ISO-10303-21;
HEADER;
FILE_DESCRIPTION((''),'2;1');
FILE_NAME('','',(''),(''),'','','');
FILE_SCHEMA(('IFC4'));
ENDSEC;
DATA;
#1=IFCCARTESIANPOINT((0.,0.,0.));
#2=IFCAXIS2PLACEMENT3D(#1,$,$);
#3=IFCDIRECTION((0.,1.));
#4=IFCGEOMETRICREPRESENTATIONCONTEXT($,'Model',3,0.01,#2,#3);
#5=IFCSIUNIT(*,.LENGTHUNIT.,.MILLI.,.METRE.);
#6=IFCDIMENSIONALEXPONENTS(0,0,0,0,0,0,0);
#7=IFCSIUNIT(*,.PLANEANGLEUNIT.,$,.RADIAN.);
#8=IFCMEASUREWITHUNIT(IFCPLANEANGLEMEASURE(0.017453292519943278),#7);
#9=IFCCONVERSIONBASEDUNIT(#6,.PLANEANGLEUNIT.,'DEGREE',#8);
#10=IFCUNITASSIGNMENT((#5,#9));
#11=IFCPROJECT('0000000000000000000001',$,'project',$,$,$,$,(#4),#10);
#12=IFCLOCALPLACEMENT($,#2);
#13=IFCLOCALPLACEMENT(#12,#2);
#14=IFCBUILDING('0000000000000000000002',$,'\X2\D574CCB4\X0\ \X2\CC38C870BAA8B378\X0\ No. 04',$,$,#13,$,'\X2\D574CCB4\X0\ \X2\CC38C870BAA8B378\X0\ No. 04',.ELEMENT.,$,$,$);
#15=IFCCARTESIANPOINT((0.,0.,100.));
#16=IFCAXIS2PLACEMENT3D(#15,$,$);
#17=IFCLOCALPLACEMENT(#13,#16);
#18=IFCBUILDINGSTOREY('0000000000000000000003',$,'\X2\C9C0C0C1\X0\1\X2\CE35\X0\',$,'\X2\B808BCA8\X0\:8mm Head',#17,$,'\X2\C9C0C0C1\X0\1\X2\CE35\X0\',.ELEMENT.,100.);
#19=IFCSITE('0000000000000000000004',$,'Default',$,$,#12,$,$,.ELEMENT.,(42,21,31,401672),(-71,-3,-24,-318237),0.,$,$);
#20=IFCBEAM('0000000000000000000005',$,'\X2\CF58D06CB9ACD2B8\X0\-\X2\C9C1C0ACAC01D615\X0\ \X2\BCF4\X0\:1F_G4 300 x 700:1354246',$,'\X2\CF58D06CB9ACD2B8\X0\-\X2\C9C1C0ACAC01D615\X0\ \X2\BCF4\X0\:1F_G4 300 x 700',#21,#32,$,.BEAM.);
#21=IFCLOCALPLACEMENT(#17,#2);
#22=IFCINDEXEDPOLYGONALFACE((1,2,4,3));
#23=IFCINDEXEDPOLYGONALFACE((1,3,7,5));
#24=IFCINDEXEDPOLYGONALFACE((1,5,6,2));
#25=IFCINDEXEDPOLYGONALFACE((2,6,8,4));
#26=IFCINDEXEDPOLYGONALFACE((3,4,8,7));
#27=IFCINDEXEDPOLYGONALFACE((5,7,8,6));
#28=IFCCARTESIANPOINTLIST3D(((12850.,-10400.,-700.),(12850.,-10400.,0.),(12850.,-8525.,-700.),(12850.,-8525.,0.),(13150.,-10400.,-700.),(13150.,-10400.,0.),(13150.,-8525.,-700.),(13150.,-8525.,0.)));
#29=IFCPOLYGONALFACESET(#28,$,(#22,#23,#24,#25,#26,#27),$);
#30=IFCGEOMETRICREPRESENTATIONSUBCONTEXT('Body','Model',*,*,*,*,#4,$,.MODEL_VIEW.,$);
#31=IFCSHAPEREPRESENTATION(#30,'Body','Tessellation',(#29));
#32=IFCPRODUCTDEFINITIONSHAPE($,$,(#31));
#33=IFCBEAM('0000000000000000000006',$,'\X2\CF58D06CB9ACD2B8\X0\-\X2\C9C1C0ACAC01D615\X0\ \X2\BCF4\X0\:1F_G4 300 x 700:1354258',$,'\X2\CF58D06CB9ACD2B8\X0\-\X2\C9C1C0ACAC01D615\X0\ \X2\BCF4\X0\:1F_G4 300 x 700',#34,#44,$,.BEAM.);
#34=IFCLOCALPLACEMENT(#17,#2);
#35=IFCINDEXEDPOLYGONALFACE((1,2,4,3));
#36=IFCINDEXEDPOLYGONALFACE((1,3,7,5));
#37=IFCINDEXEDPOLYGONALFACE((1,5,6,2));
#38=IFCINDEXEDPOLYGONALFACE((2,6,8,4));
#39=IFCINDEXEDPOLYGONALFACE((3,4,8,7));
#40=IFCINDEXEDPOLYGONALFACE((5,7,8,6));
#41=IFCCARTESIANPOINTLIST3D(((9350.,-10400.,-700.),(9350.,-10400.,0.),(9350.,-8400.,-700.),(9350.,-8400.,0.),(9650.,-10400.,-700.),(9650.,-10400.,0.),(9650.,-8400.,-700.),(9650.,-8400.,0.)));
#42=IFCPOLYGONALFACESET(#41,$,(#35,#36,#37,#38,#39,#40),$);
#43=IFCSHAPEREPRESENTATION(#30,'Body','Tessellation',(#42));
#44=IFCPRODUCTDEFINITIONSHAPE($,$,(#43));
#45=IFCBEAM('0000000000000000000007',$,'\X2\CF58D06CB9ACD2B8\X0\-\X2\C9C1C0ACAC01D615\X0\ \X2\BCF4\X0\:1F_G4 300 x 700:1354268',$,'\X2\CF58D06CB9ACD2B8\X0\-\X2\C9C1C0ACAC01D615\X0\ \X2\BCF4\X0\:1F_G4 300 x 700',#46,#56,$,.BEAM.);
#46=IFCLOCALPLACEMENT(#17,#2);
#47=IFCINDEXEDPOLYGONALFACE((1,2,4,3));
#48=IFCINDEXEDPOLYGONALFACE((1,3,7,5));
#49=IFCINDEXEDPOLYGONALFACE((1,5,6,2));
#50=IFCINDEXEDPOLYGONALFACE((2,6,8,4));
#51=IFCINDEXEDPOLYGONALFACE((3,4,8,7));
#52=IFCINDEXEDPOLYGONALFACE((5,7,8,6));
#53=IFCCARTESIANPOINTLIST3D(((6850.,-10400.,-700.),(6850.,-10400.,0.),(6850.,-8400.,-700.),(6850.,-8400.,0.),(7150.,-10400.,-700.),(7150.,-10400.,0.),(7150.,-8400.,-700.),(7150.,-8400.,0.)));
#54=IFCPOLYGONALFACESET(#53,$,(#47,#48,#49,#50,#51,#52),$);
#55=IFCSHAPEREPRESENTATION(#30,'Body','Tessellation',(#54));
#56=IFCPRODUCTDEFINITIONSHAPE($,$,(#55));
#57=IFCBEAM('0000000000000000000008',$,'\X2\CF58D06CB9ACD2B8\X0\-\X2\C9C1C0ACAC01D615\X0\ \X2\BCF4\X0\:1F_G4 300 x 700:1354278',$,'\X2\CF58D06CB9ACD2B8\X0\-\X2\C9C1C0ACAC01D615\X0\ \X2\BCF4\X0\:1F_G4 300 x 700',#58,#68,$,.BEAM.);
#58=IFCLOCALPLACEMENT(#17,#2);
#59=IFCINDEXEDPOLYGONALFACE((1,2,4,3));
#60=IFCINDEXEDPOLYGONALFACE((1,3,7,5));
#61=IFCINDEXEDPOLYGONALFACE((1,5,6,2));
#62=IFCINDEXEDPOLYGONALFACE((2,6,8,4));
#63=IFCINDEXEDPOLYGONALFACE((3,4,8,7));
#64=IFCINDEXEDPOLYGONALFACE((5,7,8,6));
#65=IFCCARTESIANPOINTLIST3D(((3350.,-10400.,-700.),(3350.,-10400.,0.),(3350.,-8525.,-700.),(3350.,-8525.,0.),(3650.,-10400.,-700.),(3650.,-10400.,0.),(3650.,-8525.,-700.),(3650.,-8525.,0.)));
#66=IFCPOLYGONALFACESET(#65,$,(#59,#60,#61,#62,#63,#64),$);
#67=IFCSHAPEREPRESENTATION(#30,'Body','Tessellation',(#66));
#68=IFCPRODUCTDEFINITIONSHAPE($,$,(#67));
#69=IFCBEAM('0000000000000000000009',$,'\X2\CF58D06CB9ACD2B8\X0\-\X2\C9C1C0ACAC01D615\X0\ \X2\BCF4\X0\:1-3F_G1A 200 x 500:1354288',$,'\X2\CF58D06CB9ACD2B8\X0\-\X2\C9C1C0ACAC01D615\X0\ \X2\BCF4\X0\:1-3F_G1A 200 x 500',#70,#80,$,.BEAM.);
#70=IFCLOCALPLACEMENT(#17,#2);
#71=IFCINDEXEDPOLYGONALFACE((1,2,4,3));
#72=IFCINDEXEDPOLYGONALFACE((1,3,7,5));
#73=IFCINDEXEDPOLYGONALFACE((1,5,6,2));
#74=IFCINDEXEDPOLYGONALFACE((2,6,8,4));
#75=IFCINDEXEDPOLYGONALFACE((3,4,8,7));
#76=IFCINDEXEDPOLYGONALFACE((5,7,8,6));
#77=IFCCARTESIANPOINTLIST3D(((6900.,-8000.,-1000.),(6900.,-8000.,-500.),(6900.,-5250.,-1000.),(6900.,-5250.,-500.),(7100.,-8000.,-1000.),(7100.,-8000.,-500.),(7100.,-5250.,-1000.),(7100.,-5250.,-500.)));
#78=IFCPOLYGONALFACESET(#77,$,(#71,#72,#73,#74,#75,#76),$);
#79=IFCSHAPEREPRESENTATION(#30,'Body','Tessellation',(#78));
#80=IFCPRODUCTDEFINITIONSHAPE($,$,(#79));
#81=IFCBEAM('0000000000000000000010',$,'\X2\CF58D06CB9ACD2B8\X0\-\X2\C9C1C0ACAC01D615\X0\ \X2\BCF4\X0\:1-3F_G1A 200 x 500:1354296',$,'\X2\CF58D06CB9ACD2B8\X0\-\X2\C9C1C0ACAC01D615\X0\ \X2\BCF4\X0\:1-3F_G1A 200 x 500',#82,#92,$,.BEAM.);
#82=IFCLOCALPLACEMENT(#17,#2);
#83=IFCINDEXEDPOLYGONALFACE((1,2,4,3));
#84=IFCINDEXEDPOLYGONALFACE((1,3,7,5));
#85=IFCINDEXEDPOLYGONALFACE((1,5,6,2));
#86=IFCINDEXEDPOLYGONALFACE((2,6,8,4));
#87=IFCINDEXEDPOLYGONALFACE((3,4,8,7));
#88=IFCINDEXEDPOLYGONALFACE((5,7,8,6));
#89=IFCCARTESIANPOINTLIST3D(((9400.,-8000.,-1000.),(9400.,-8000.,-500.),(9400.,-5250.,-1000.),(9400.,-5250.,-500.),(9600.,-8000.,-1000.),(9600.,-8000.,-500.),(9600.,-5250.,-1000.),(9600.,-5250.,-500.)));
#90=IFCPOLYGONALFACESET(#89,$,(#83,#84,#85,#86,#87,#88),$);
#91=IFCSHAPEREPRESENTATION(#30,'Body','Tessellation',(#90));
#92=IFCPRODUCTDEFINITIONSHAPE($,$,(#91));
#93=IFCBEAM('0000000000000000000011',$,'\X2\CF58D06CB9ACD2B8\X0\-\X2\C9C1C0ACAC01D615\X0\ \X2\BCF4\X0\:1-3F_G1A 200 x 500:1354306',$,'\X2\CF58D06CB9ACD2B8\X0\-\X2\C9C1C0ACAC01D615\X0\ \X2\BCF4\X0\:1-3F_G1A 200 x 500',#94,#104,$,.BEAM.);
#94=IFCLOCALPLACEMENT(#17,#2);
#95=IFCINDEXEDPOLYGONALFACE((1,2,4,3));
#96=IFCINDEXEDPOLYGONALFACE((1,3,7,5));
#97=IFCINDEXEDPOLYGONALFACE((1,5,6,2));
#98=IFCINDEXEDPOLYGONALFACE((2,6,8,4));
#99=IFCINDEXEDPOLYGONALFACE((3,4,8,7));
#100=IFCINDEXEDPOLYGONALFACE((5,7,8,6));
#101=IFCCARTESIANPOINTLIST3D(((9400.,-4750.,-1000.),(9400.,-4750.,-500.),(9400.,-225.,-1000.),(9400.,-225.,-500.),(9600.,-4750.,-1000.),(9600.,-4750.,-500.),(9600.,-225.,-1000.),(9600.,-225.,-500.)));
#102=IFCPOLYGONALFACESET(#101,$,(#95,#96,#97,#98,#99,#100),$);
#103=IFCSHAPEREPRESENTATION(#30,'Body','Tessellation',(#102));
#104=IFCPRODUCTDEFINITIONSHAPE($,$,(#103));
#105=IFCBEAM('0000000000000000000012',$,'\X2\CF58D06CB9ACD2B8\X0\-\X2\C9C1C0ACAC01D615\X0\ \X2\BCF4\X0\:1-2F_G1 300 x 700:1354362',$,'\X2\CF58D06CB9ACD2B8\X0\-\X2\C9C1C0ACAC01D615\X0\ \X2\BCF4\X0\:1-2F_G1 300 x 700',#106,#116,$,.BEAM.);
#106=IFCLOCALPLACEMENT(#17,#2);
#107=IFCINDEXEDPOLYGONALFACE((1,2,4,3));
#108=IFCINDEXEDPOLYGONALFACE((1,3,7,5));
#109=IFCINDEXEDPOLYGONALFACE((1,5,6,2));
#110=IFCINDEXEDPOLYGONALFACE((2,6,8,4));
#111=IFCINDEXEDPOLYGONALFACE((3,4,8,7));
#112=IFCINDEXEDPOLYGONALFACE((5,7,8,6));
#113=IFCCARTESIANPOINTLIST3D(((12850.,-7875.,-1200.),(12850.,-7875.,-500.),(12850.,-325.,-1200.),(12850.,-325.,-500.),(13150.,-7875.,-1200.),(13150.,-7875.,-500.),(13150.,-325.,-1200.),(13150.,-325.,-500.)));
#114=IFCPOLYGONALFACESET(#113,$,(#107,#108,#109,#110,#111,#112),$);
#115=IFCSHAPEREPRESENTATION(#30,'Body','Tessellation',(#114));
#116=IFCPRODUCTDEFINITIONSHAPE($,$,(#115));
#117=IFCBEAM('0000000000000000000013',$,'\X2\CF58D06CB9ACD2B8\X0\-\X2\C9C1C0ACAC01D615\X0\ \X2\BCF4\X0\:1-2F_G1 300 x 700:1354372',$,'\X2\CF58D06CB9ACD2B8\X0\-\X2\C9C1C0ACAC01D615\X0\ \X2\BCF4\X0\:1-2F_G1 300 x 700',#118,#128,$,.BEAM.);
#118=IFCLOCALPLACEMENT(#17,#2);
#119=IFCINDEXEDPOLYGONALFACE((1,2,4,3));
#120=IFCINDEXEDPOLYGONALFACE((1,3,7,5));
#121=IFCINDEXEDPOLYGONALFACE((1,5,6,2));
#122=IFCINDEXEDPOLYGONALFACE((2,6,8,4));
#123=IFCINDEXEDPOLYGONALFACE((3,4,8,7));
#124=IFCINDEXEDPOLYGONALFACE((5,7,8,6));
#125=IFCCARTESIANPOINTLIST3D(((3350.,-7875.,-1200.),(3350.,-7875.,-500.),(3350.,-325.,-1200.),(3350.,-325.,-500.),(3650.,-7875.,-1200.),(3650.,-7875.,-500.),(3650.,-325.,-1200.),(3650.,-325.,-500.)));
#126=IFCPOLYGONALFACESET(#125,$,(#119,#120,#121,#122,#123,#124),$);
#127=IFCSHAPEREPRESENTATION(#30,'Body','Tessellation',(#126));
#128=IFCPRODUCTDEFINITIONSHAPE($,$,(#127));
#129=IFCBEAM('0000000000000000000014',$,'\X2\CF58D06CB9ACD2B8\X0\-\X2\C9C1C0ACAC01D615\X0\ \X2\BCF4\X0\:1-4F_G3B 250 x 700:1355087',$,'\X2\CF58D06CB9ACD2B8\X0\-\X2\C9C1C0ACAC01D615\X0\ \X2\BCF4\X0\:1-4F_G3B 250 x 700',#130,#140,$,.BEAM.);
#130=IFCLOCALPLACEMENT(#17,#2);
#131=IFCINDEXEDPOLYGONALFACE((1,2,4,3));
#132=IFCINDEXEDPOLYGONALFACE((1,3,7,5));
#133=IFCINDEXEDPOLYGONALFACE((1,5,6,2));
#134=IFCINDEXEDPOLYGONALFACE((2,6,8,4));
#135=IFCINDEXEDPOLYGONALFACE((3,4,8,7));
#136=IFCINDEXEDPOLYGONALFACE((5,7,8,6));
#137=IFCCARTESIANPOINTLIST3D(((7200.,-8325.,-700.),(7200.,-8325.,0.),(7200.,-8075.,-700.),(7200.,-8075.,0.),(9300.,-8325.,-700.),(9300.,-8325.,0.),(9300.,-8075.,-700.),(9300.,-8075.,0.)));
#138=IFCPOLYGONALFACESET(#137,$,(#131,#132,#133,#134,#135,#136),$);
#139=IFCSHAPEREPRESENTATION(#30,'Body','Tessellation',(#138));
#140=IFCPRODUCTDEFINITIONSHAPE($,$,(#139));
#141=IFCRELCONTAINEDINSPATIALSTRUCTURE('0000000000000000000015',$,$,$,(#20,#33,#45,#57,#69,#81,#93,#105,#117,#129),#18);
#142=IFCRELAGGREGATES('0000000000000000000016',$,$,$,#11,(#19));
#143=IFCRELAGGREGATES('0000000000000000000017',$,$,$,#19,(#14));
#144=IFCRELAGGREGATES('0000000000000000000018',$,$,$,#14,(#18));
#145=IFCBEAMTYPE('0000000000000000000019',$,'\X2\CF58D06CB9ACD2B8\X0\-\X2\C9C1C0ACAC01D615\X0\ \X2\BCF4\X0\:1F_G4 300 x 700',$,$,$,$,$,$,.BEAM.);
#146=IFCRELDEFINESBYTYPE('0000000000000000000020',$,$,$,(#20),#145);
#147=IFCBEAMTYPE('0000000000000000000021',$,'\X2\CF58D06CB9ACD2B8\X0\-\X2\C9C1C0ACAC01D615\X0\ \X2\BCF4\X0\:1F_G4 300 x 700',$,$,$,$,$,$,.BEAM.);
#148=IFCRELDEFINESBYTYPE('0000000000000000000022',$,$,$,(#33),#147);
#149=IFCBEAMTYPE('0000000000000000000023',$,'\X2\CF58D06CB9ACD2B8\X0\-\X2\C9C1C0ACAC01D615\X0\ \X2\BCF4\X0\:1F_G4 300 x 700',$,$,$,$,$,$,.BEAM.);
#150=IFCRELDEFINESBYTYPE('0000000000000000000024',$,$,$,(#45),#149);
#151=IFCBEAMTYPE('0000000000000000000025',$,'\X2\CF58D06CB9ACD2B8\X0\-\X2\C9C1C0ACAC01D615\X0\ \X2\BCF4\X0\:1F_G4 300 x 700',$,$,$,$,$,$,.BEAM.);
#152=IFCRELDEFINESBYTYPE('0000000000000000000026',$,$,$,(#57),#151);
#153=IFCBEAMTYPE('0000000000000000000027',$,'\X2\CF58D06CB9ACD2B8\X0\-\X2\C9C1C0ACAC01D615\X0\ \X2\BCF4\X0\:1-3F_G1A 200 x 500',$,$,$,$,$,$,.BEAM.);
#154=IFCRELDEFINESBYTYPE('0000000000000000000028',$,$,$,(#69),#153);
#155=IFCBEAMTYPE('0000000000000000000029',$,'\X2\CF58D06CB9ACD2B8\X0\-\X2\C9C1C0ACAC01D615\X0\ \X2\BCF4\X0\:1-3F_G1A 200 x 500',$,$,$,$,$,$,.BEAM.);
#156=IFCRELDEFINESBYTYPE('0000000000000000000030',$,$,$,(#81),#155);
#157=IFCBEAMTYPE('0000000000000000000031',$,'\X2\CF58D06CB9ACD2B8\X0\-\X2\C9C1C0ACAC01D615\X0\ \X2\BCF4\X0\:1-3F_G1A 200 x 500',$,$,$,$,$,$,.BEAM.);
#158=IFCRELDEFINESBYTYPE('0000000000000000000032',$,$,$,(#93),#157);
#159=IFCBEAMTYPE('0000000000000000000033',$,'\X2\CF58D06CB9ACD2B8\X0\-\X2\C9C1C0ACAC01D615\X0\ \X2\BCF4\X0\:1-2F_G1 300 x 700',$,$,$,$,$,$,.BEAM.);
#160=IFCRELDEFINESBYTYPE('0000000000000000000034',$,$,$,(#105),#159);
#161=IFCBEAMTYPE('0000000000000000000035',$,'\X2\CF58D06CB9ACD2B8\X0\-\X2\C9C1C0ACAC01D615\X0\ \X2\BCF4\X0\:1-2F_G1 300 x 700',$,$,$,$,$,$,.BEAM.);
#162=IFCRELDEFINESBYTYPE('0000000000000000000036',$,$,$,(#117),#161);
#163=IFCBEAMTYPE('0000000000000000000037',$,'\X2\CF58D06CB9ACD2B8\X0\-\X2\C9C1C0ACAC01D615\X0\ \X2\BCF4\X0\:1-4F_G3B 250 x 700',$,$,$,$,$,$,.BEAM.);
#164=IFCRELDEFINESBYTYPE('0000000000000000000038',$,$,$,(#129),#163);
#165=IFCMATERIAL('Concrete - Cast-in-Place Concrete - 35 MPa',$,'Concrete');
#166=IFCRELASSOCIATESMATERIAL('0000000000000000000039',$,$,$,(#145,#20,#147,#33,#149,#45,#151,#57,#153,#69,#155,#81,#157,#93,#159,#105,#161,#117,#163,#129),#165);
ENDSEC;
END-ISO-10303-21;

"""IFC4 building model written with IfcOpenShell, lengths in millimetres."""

from ifc_helpers import new_model, entity, si_unit, converted_unit, direction, frame, origin, place, context, subcontext, project, spatial, indexed_curve, outline, extrude, source, transform, mapped, material, type_object, type_shapes, element, save


model = new_model("IFC4")

# Units and contexts
model_context = context("Model", 3, precision=0.01, world=origin(), true_north=direction((0.0, 1.0)))
body_context = subcontext(model_context, "Body", "Model", "MODEL_VIEW")
ifc_project = project(units=[si_unit("LENGTHUNIT", "METRE", prefix="MILLI"), converted_unit("PLANEANGLEUNIT", "DEGREE", entity("IfcPlaneAngleMeasure", 0.017453292519943278), si_unit("PLANEANGLEUNIT", "RADIAN"), dimensions=[0, 0, 0, 0, 0, 0, 0])], contexts=[model_context])

# Site, building, storey
site_placement = place(None, origin())
site = spatial("IfcSite", under=ifc_project, at=site_placement, Name="Default", CompositionType="ELEMENT", RefLatitude=(42, 21, 31, 401672), RefLongitude=(-71, -3, -24, -318237), RefElevation=0.0)
building_placement = place(site_placement, origin())
building = spatial("IfcBuilding", under=site, at=building_placement, Name="해체 참조모델 No. 04", LongName="해체 참조모델 No. 04", CompositionType="ELEMENT")
storey_placement = place(building_placement, frame((0.0, 0.0, 100.0)))
storey = spatial("IfcBuildingStorey", under=building, at=storey_placement, Name="지상1층", ObjectType="레벨:8mm Head", LongName="지상1층", CompositionType="ELEMENT", Elevation=100.0)

# Beams
ifc_material = material(Name="Concrete - Cast-in-Place Concrete - 35 MPa", Category="Concrete")
beam_type_1 = type_object("IfcBeamType", Name="콘크리트-직사각형 보:1F_G4 300 x 700", PredefinedType="BEAM", material=ifc_material)
shared_shape_1 = source(origin(), body_context, "Body", "SweptSolid", [
    extrude(outline(indexed_curve([(-150.0, -350.0), (150.0, -350.0), (150.0, 350.0), (-150.0, 350.0), (-150.0, -350.0)], self_intersect=False)), frame((13000.0, -8525.0, -250.0), z_axis=(0.0, -1.0, 0.0), x_axis=(-1.0, 0.0, 0.0)), (0.0, 0.0, 1.0), 1875.0),
])
type_shapes(beam_type_1, [shared_shape_1])
beam_1_placement = place(storey_placement, frame((0.0, 0.0, -100.0)))
element("IfcBeam", 1, at=beam_1_placement, inside=storey, type_object=beam_type_1, material=ifc_material, Name="콘크리트-직사각형 보:1F_G4 300 x 700:1354246", ObjectType="콘크리트-직사각형 보:1F_G4 300 x 700", PredefinedType="BEAM", context=body_context, shape_type="MappedRepresentation", body=[
    mapped(shared_shape_1, transform((0.0, 0.0, 0.0), scale=1.0)),
])
beam_type_2 = type_object("IfcBeamType", Name="콘크리트-직사각형 보:1F_G4 300 x 700", PredefinedType="BEAM", material=ifc_material)
shared_shape_2 = source(origin(), body_context, "Body", "SweptSolid", [
    extrude(outline(indexed_curve([(-150.0, -350.0), (150.0, -350.0), (150.0, 350.0), (-150.0, 350.0), (-150.0, -350.0)], self_intersect=False)), frame((9500.0, -8400.0, -250.0), z_axis=(0.0, -1.0, 0.0), x_axis=(-1.0, 0.0, 0.0)), (0.0, 0.0, 1.0), 2000.0),
])
type_shapes(beam_type_2, [shared_shape_2])
beam_2_placement = place(storey_placement, frame((0.0, 0.0, -100.0)))
element("IfcBeam", 2, at=beam_2_placement, inside=storey, type_object=beam_type_2, material=ifc_material, Name="콘크리트-직사각형 보:1F_G4 300 x 700:1354258", ObjectType="콘크리트-직사각형 보:1F_G4 300 x 700", PredefinedType="BEAM", context=body_context, shape_type="MappedRepresentation", body=[
    mapped(shared_shape_2, transform((0.0, 0.0, 0.0), scale=1.0)),
])
beam_type_3 = type_object("IfcBeamType", Name="콘크리트-직사각형 보:1F_G4 300 x 700", PredefinedType="BEAM", material=ifc_material)
shared_shape_3 = source(origin(), body_context, "Body", "SweptSolid", [
    extrude(outline(indexed_curve([(-150.0, -350.0), (150.0, -350.0), (150.0, 350.0), (-150.0, 350.0), (-150.0, -350.0)], self_intersect=False)), frame((7000.0, -8400.0, -250.0), z_axis=(0.0, -1.0, 0.0), x_axis=(-1.0, 0.0, 0.0)), (0.0, 0.0, 1.0), 2000.0),
])
type_shapes(beam_type_3, [shared_shape_3])
beam_3_placement = place(storey_placement, frame((0.0, 0.0, -100.0)))
element("IfcBeam", 3, at=beam_3_placement, inside=storey, type_object=beam_type_3, material=ifc_material, Name="콘크리트-직사각형 보:1F_G4 300 x 700:1354268", ObjectType="콘크리트-직사각형 보:1F_G4 300 x 700", PredefinedType="BEAM", context=body_context, shape_type="MappedRepresentation", body=[
    mapped(shared_shape_3, transform((0.0, 0.0, 0.0), scale=1.0)),
])
beam_type_4 = type_object("IfcBeamType", Name="콘크리트-직사각형 보:1F_G4 300 x 700", PredefinedType="BEAM", material=ifc_material)
shared_shape_4 = source(origin(), body_context, "Body", "SweptSolid", [
    extrude(outline(indexed_curve([(-150.0, -350.0), (150.0, -350.0), (150.0, 350.0), (-150.0, 350.0), (-150.0, -350.0)], self_intersect=False)), frame((3500.0, -8525.0, -250.0), z_axis=(0.0, -1.0, 0.0), x_axis=(-1.0, 0.0, 0.0)), (0.0, 0.0, 1.0), 1875.0),
])
type_shapes(beam_type_4, [shared_shape_4])
beam_4_placement = place(storey_placement, frame((0.0, 0.0, -100.0)))
element("IfcBeam", 4, at=beam_4_placement, inside=storey, type_object=beam_type_4, material=ifc_material, Name="콘크리트-직사각형 보:1F_G4 300 x 700:1354278", ObjectType="콘크리트-직사각형 보:1F_G4 300 x 700", PredefinedType="BEAM", context=body_context, shape_type="MappedRepresentation", body=[
    mapped(shared_shape_4, transform((0.0, 0.0, 0.0), scale=1.0)),
])
beam_type_5 = type_object("IfcBeamType", Name="콘크리트-직사각형 보:1-3F_G1A 200 x 500", PredefinedType="BEAM", material=ifc_material)
shared_shape_5 = source(origin(), body_context, "Body", "SweptSolid", [
    extrude(outline(indexed_curve([(-100.0, -250.0), (100.0, -250.0), (100.0, 250.0), (-100.0, 250.0), (-100.0, -250.0)], self_intersect=False)), frame((7000.0, -5250.0, -650.0), z_axis=(0.0, -1.0, 0.0), x_axis=(-1.0, 0.0, 0.0)), (0.0, 0.0, 1.0), 2750.0),
])
type_shapes(beam_type_5, [shared_shape_5])
beam_5_placement = place(storey_placement, frame((0.0, 0.0, -100.0)))
element("IfcBeam", 5, at=beam_5_placement, inside=storey, type_object=beam_type_5, material=ifc_material, Name="콘크리트-직사각형 보:1-3F_G1A 200 x 500:1354288", ObjectType="콘크리트-직사각형 보:1-3F_G1A 200 x 500", PredefinedType="BEAM", context=body_context, shape_type="MappedRepresentation", body=[
    mapped(shared_shape_5, transform((0.0, 0.0, 0.0), scale=1.0)),
])
beam_type_6 = type_object("IfcBeamType", Name="콘크리트-직사각형 보:1-3F_G1A 200 x 500", PredefinedType="BEAM", material=ifc_material)
shared_shape_6 = source(origin(), body_context, "Body", "SweptSolid", [
    extrude(outline(indexed_curve([(-100.0, -250.0), (100.0, -250.0), (100.0, 250.0), (-100.0, 250.0), (-100.0, -250.0)], self_intersect=False)), frame((9500.0, -5250.0, -650.0), z_axis=(0.0, -1.0, 0.0), x_axis=(-1.0, 0.0, 0.0)), (0.0, 0.0, 1.0), 2750.0),
])
type_shapes(beam_type_6, [shared_shape_6])
beam_6_placement = place(storey_placement, frame((0.0, 0.0, -100.0)))
element("IfcBeam", 6, at=beam_6_placement, inside=storey, type_object=beam_type_6, material=ifc_material, Name="콘크리트-직사각형 보:1-3F_G1A 200 x 500:1354296", ObjectType="콘크리트-직사각형 보:1-3F_G1A 200 x 500", PredefinedType="BEAM", context=body_context, shape_type="MappedRepresentation", body=[
    mapped(shared_shape_6, transform((0.0, 0.0, 0.0), scale=1.0)),
])
beam_type_7 = type_object("IfcBeamType", Name="콘크리트-직사각형 보:1-3F_G1A 200 x 500", PredefinedType="BEAM", material=ifc_material)
shared_shape_7 = source(origin(), body_context, "Body", "SweptSolid", [
    extrude(outline(indexed_curve([(-100.0, -250.0), (100.0, -250.0), (100.0, 250.0), (-100.0, 250.0), (-100.0, -250.0)], self_intersect=False)), frame((9500.0, -225.0, -650.0), z_axis=(0.0, -1.0, 0.0), x_axis=(-1.0, 0.0, 0.0)), (0.0, 0.0, 1.0), 4525.0),
])
type_shapes(beam_type_7, [shared_shape_7])
beam_7_placement = place(storey_placement, frame((0.0, 0.0, -100.0)))
element("IfcBeam", 7, at=beam_7_placement, inside=storey, type_object=beam_type_7, material=ifc_material, Name="콘크리트-직사각형 보:1-3F_G1A 200 x 500:1354306", ObjectType="콘크리트-직사각형 보:1-3F_G1A 200 x 500", PredefinedType="BEAM", context=body_context, shape_type="MappedRepresentation", body=[
    mapped(shared_shape_7, transform((0.0, 0.0, 0.0), scale=1.0)),
])
beam_type_8 = type_object("IfcBeamType", Name="콘크리트-직사각형 보:1-2F_G1 300 x 700", PredefinedType="BEAM", material=ifc_material)
shared_shape_8 = source(origin(), body_context, "Body", "SweptSolid", [
    extrude(outline(indexed_curve([(-150.0, -350.0), (150.0, -350.0), (150.0, 350.0), (-150.0, 350.0), (-150.0, -350.0)], self_intersect=False)), frame((13000.0, -325.0, -750.0), z_axis=(0.0, -1.0, 0.0), x_axis=(-1.0, 0.0, 0.0)), (0.0, 0.0, 1.0), 7550.0),
])
type_shapes(beam_type_8, [shared_shape_8])
beam_8_placement = place(storey_placement, frame((0.0, 0.0, -100.0)))
element("IfcBeam", 8, at=beam_8_placement, inside=storey, type_object=beam_type_8, material=ifc_material, Name="콘크리트-직사각형 보:1-2F_G1 300 x 700:1354362", ObjectType="콘크리트-직사각형 보:1-2F_G1 300 x 700", PredefinedType="BEAM", context=body_context, shape_type="MappedRepresentation", body=[
    mapped(shared_shape_8, transform((0.0, 0.0, 0.0), scale=1.0)),
])
beam_type_9 = type_object("IfcBeamType", Name="콘크리트-직사각형 보:1-2F_G1 300 x 700", PredefinedType="BEAM", material=ifc_material)
shared_shape_9 = source(origin(), body_context, "Body", "SweptSolid", [
    extrude(outline(indexed_curve([(-150.0, -350.0), (150.0, -350.0), (150.0, 350.0), (-150.0, 350.0), (-150.0, -350.0)], self_intersect=False)), frame((3500.0, -325.0, -750.0), z_axis=(0.0, -1.0, 0.0), x_axis=(-1.0, 0.0, 0.0)), (0.0, 0.0, 1.0), 7550.0),
])
type_shapes(beam_type_9, [shared_shape_9])
beam_9_placement = place(storey_placement, frame((0.0, 0.0, -100.0)))
element("IfcBeam", 9, at=beam_9_placement, inside=storey, type_object=beam_type_9, material=ifc_material, Name="콘크리트-직사각형 보:1-2F_G1 300 x 700:1354372", ObjectType="콘크리트-직사각형 보:1-2F_G1 300 x 700", PredefinedType="BEAM", context=body_context, shape_type="MappedRepresentation", body=[
    mapped(shared_shape_9, transform((0.0, 0.0, 0.0), scale=1.0)),
])
beam_type_10 = type_object("IfcBeamType", Name="콘크리트-직사각형 보:1-4F_G3B 250 x 700", PredefinedType="BEAM", material=ifc_material)
shared_shape_10 = source(origin(), body_context, "Body", "SweptSolid", [
    extrude(outline(indexed_curve([(-350.0, -125.0), (350.0, -125.0), (350.0, 125.0), (-350.0, 125.0), (-350.0, -125.0)], self_intersect=False)), frame((7200.0, -8200.0, -250.0), z_axis=(1.0, 0.0, 0.0), x_axis=(0.0, 0.0, -1.0)), (0.0, 0.0, 1.0), 2100.0),
])
type_shapes(beam_type_10, [shared_shape_10])
beam_10_placement = place(storey_placement, frame((0.0, 0.0, -100.0)))
element("IfcBeam", 10, at=beam_10_placement, inside=storey, type_object=beam_type_10, material=ifc_material, Name="콘크리트-직사각형 보:1-4F_G3B 250 x 700:1355087", ObjectType="콘크리트-직사각형 보:1-4F_G3B 250 x 700", PredefinedType="BEAM", context=body_context, shape_type="MappedRepresentation", body=[
    mapped(shared_shape_10, transform((0.0, 0.0, 0.0), scale=1.0)),
])

save(model, "model.ifc")
